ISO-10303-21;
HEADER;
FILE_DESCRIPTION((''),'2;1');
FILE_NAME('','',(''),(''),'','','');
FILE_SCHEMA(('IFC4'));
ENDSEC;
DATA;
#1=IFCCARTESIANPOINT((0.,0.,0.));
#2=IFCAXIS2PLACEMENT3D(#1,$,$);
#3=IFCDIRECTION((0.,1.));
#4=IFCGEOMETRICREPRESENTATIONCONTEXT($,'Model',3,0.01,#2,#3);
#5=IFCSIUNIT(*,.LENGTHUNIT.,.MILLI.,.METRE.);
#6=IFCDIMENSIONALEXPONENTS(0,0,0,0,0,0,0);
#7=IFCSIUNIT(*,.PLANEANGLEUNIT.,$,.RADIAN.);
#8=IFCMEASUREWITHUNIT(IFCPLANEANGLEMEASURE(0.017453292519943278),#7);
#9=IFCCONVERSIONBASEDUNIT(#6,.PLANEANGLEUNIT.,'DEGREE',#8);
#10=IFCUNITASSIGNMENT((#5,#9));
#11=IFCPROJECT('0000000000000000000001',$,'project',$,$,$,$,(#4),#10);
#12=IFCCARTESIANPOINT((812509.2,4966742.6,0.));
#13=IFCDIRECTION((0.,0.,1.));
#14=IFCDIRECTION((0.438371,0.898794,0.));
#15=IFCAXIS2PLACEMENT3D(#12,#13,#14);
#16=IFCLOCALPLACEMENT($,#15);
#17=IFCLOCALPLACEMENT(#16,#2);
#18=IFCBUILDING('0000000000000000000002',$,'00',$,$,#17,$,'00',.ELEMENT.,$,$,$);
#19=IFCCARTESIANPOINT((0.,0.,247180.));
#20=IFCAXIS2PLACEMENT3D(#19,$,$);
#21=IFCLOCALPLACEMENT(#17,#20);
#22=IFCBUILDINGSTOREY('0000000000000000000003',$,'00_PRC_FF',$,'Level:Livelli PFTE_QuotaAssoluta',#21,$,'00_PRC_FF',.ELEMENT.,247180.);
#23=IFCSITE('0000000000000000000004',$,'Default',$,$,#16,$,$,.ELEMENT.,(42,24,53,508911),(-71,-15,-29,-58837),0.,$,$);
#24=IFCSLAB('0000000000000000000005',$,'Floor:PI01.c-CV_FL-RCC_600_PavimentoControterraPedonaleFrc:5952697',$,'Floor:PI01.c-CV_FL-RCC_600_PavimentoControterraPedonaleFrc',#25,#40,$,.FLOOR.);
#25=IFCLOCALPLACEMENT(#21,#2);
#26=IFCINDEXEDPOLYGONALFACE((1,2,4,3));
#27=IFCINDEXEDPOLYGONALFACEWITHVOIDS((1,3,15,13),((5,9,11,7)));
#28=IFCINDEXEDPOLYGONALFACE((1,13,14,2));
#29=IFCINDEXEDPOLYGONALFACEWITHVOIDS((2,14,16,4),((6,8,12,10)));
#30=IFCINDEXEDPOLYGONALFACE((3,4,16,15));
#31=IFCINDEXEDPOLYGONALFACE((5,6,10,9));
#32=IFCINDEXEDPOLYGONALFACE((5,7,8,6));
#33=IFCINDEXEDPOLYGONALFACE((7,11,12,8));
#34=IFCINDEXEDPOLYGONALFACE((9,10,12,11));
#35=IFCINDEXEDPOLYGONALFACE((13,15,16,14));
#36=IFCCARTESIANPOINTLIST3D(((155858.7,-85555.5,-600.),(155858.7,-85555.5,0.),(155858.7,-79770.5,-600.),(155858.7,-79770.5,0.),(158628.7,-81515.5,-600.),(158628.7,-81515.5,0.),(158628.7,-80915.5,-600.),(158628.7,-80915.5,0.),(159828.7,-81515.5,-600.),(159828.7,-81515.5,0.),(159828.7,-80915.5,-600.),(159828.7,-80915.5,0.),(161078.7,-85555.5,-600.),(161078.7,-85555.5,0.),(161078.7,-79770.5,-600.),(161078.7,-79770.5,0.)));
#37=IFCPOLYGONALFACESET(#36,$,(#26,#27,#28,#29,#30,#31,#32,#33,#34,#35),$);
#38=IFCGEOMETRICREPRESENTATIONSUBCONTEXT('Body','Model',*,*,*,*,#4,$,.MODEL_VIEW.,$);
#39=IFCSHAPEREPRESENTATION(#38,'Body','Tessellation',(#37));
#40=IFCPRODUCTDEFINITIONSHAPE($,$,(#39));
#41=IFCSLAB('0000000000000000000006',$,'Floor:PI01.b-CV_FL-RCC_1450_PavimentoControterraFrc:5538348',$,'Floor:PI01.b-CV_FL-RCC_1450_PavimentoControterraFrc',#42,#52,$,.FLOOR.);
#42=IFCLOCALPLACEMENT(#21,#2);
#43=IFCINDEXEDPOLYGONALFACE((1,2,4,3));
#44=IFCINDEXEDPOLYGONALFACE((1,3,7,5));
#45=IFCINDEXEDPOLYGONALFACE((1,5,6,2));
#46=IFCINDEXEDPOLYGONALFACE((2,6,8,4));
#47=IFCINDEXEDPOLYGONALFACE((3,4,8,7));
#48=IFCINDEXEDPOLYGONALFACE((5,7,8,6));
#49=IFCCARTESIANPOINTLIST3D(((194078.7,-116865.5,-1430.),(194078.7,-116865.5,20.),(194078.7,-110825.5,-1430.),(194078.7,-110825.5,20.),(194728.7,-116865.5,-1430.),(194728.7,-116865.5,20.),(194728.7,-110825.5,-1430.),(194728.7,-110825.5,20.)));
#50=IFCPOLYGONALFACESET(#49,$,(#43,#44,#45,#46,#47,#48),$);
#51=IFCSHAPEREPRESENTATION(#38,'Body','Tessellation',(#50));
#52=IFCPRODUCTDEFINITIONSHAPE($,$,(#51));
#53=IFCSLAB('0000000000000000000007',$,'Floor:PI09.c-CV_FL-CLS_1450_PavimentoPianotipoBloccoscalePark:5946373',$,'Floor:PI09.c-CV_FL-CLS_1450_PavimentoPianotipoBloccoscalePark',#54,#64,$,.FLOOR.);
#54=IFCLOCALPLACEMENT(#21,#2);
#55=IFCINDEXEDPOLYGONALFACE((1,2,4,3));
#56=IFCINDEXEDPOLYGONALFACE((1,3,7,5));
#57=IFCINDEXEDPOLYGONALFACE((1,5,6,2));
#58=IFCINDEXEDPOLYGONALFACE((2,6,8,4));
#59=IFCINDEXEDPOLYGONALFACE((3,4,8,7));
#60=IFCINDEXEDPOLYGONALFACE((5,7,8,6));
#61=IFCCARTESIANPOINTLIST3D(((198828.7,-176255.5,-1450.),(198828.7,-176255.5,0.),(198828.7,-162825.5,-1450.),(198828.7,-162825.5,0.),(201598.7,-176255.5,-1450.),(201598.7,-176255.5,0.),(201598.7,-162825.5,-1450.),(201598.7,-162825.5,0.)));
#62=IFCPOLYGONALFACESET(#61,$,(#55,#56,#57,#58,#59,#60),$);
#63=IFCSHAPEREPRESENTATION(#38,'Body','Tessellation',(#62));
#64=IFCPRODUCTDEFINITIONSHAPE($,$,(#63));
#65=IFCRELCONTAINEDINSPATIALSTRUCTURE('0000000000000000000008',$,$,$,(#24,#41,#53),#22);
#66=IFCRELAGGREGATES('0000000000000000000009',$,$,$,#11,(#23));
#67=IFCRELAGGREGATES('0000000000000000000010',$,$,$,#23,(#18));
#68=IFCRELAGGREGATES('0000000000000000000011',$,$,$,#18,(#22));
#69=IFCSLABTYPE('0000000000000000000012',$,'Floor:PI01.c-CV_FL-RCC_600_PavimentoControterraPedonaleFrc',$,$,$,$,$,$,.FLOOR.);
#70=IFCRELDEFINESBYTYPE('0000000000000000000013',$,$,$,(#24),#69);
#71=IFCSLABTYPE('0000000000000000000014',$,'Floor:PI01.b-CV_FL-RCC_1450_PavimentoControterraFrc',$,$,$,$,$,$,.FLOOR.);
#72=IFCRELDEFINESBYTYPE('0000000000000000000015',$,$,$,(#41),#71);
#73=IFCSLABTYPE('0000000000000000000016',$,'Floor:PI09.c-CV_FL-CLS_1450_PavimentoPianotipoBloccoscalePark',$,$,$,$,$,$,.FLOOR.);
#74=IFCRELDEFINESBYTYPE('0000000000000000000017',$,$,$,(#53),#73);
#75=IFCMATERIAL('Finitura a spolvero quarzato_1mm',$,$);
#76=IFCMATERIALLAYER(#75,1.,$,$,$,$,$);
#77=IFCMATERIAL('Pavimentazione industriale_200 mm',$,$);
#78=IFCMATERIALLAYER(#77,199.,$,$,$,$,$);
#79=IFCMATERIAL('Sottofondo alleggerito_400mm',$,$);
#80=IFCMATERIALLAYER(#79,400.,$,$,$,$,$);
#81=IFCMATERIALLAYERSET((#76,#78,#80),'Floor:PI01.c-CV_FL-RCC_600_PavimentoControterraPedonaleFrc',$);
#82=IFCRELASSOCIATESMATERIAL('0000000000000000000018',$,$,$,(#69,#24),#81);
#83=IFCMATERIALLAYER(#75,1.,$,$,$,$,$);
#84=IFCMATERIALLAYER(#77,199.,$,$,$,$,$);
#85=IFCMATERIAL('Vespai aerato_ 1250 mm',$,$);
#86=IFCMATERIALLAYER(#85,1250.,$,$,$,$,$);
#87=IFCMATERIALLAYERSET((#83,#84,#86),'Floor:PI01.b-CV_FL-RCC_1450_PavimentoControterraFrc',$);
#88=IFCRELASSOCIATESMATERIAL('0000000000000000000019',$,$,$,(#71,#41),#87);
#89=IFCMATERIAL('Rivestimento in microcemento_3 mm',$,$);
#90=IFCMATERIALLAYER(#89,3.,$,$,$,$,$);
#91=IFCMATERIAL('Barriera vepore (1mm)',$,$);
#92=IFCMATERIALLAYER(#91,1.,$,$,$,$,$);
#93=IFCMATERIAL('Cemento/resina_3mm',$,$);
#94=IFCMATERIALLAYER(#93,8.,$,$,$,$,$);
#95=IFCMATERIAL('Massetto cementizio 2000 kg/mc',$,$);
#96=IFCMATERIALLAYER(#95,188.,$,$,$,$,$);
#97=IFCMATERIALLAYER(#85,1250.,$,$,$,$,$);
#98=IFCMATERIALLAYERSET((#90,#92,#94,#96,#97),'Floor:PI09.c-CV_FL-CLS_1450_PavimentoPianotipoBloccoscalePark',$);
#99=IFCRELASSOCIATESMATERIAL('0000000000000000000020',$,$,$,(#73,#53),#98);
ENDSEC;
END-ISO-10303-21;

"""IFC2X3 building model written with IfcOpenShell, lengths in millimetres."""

from ifc_helpers import new_model, entity, si_unit, converted_unit, direction, frame, frame_2d, origin, origin_2d_with_axis, place, context, subcontext, project, spatial, rectangle, extrude, boolean, material, layer, layer_set, layer_usage, type_object, element, save


model = new_model("IFC2X3")

# Units and contexts
model_context = context("Model", 3, precision=0.01, world=origin(), true_north=direction((0.0, 1.0)))
body_context = subcontext(model_context, "Body", "Model", "MODEL_VIEW")
ifc_project = project(units=[si_unit("LENGTHUNIT", "METRE", prefix="MILLI"), converted_unit("PLANEANGLEUNIT", "DEGREE", entity("IfcPlaneAngleMeasure", 0.017453292519943278), si_unit("PLANEANGLEUNIT", "RADIAN"), dimensions=[0, 0, 0, 0, 0, 0, 0])], contexts=[model_context])

# Site, building, storey
site_placement = place(None, frame((812509.2, 4966742.6, 0.0), z_axis=(0.0, 0.0, 1.0), x_axis=(0.438371, 0.898794, 0.0)))
site = spatial("IfcSite", under=ifc_project, at=site_placement, Name="Default", CompositionType="ELEMENT", RefLatitude=(42, 24, 53, 508911), RefLongitude=(-71, -15, -29, -58837), RefElevation=0.0)
building_placement = place(site_placement, origin())
building = spatial("IfcBuilding", under=site, at=building_placement, Name="00", LongName="00", CompositionType="ELEMENT")
storey_placement = place(building_placement, frame((0.0, 0.0, 247180.0)))
storey = spatial("IfcBuildingStorey", under=building, at=storey_placement, Name="00_PRC_FF", ObjectType="Level:Livelli PFTE_QuotaAssoluta", LongName="00_PRC_FF", CompositionType="ELEMENT", Elevation=247180.0)

# Shared definitions
ifc_material_1 = material(Name="Finitura a spolvero quarzato_1mm")
ifc_layer_1 = layer(ifc_material_1, 1.0)
ifc_material_2 = material(Name="Pavimentazione industriale_200 mm")
ifc_layer_2 = layer(ifc_material_2, 199.0)
ifc_material_3 = material(Name="Sottofondo alleggerito_400mm")
ifc_layer_3 = layer(ifc_material_3, 400.0)
ifc_layer_set_1 = layer_set([ifc_layer_1, ifc_layer_2, ifc_layer_3], Name="Floor:PI01.c-CV_FL-RCC_600_PavimentoControterraPedonaleFrc")
slab_type_1 = type_object("IfcSlabType", Name="Floor:PI01.c-CV_FL-RCC_600_PavimentoControterraPedonaleFrc", PredefinedType="FLOOR", material=ifc_layer_set_1)

# Slab, opening
ifc_layer_usage_1 = layer_usage(ifc_layer_set_1, "AXIS3", "POSITIVE", 0.0)
slab_1_placement = place(storey_placement, origin())
slab_1 = element("IfcSlab", 1, at=slab_1_placement, inside=storey, type_object=slab_type_1, material=ifc_layer_usage_1, Name="Floor:PI01.c-CV_FL-RCC_600_PavimentoControterraPedonaleFrc:5952697", ObjectType="Floor:PI01.c-CV_FL-RCC_600_PavimentoControterraPedonaleFrc", PredefinedType="FLOOR", context=body_context, shape_type="SweptSolid", body=[
    boolean("DIFFERENCE", extrude(rectangle(XDim=5785.0, YDim=5220.0, at=frame_2d((0.0, 0.0), x_axis=(1.0, 0.0))), frame((158468.7, -82663.0, 0.0), z_axis=(0.0, 0.0, -1.0), x_axis=(0.0, 1.0, 0.0)), (0.0, 0.0, 1.0), 600.0), extrude(rectangle(XDim=600.0, YDim=1200.0, at=origin_2d_with_axis()), frame((159228.7, -81215.5, -600.0), z_axis=(0.0, 0.0, 1.0), x_axis=(0.0, 1.0, 0.0)), (0.0, 0.0, 1.0), 600.0)),
])
opening_1_placement = place(slab_1_placement, origin())
element("IfcOpeningElement", 2, at=opening_1_placement, cuts=slab_1, ObjectType="Opening", context=body_context, shape_type="SweptSolid", body=[
    extrude(rectangle(XDim=600.0, YDim=1200.0, at=origin_2d_with_axis()), frame((159228.7, -81215.5, 0.0), z_axis=(0.0, 0.0, -1.0), x_axis=(0.0, -1.0, 0.0)), (0.0, 0.0, 1.0), 600.0),
])

# Slab
ifc_layer_4 = layer(ifc_material_1, 1.0)
ifc_layer_5 = layer(ifc_material_2, 199.0)
ifc_material_4 = material(Name="Vespai aerato_ 1250 mm")
ifc_layer_6 = layer(ifc_material_4, 1250.0)
ifc_layer_set_2 = layer_set([ifc_layer_4, ifc_layer_5, ifc_layer_6], Name="Floor:PI01.b-CV_FL-RCC_1450_PavimentoControterraFrc")
slab_type_2 = type_object("IfcSlabType", Name="Floor:PI01.b-CV_FL-RCC_1450_PavimentoControterraFrc", PredefinedType="FLOOR", material=ifc_layer_set_2)
ifc_layer_usage_2 = layer_usage(ifc_layer_set_2, "AXIS3", "POSITIVE", 0.0)
slab_2_placement = place(storey_placement, origin())
element("IfcSlab", 3, at=slab_2_placement, inside=storey, type_object=slab_type_2, material=ifc_layer_usage_2, Name="Floor:PI01.b-CV_FL-RCC_1450_PavimentoControterraFrc:5538348", ObjectType="Floor:PI01.b-CV_FL-RCC_1450_PavimentoControterraFrc", PredefinedType="FLOOR", context=body_context, shape_type="SweptSolid", body=[
    extrude(rectangle(XDim=6040.0, YDim=650.0, at=frame_2d((0.0, 0.0), x_axis=(1.0, 0.0))), frame((194403.7, -113845.5, 20.0), z_axis=(0.0, 0.0, -1.0), x_axis=(0.0, 1.0, 0.0)), (0.0, 0.0, 1.0), 1450.0),
])

# Shared definitions
ifc_material_5 = material(Name="Rivestimento in microcemento_3 mm")
ifc_layer_7 = layer(ifc_material_5, 3.0)
ifc_material_6 = material(Name="Barriera vepore (1mm)")
ifc_layer_8 = layer(ifc_material_6, 1.0)
ifc_material_7 = material(Name="Cemento/resina_3mm")
ifc_layer_9 = layer(ifc_material_7, 8.0)
ifc_material_8 = material(Name="Massetto cementizio 2000 kg/mc")
ifc_layer_10 = layer(ifc_material_8, 188.0)
ifc_layer_11 = layer(ifc_material_4, 1250.0)
ifc_layer_set_3 = layer_set([ifc_layer_7, ifc_layer_8, ifc_layer_9, ifc_layer_10, ifc_layer_11], Name="Floor:PI09.c-CV_FL-CLS_1450_PavimentoPianotipoBloccoscalePark")
slab_type_3 = type_object("IfcSlabType", Name="Floor:PI09.c-CV_FL-CLS_1450_PavimentoPianotipoBloccoscalePark", PredefinedType="FLOOR", material=ifc_layer_set_3)

# Slab
ifc_layer_usage_3 = layer_usage(ifc_layer_set_3, "AXIS3", "POSITIVE", 0.0)
slab_3_placement = place(storey_placement, origin())
element("IfcSlab", 4, at=slab_3_placement, inside=storey, type_object=slab_type_3, material=ifc_layer_usage_3, Name="Floor:PI09.c-CV_FL-CLS_1450_PavimentoPianotipoBloccoscalePark:5946373", ObjectType="Floor:PI09.c-CV_FL-CLS_1450_PavimentoPianotipoBloccoscalePark", PredefinedType="FLOOR", context=body_context, shape_type="SweptSolid", body=[
    extrude(rectangle(XDim=13430.0, YDim=2770.0, at=frame_2d((0.0, 0.0), x_axis=(1.0, 0.0))), frame((200213.7, -169540.5, 0.0), z_axis=(0.0, 0.0, -1.0), x_axis=(0.0, 1.0, 0.0)), (0.0, 0.0, 1.0), 1450.0),
])

save(model, "model.ifc")
